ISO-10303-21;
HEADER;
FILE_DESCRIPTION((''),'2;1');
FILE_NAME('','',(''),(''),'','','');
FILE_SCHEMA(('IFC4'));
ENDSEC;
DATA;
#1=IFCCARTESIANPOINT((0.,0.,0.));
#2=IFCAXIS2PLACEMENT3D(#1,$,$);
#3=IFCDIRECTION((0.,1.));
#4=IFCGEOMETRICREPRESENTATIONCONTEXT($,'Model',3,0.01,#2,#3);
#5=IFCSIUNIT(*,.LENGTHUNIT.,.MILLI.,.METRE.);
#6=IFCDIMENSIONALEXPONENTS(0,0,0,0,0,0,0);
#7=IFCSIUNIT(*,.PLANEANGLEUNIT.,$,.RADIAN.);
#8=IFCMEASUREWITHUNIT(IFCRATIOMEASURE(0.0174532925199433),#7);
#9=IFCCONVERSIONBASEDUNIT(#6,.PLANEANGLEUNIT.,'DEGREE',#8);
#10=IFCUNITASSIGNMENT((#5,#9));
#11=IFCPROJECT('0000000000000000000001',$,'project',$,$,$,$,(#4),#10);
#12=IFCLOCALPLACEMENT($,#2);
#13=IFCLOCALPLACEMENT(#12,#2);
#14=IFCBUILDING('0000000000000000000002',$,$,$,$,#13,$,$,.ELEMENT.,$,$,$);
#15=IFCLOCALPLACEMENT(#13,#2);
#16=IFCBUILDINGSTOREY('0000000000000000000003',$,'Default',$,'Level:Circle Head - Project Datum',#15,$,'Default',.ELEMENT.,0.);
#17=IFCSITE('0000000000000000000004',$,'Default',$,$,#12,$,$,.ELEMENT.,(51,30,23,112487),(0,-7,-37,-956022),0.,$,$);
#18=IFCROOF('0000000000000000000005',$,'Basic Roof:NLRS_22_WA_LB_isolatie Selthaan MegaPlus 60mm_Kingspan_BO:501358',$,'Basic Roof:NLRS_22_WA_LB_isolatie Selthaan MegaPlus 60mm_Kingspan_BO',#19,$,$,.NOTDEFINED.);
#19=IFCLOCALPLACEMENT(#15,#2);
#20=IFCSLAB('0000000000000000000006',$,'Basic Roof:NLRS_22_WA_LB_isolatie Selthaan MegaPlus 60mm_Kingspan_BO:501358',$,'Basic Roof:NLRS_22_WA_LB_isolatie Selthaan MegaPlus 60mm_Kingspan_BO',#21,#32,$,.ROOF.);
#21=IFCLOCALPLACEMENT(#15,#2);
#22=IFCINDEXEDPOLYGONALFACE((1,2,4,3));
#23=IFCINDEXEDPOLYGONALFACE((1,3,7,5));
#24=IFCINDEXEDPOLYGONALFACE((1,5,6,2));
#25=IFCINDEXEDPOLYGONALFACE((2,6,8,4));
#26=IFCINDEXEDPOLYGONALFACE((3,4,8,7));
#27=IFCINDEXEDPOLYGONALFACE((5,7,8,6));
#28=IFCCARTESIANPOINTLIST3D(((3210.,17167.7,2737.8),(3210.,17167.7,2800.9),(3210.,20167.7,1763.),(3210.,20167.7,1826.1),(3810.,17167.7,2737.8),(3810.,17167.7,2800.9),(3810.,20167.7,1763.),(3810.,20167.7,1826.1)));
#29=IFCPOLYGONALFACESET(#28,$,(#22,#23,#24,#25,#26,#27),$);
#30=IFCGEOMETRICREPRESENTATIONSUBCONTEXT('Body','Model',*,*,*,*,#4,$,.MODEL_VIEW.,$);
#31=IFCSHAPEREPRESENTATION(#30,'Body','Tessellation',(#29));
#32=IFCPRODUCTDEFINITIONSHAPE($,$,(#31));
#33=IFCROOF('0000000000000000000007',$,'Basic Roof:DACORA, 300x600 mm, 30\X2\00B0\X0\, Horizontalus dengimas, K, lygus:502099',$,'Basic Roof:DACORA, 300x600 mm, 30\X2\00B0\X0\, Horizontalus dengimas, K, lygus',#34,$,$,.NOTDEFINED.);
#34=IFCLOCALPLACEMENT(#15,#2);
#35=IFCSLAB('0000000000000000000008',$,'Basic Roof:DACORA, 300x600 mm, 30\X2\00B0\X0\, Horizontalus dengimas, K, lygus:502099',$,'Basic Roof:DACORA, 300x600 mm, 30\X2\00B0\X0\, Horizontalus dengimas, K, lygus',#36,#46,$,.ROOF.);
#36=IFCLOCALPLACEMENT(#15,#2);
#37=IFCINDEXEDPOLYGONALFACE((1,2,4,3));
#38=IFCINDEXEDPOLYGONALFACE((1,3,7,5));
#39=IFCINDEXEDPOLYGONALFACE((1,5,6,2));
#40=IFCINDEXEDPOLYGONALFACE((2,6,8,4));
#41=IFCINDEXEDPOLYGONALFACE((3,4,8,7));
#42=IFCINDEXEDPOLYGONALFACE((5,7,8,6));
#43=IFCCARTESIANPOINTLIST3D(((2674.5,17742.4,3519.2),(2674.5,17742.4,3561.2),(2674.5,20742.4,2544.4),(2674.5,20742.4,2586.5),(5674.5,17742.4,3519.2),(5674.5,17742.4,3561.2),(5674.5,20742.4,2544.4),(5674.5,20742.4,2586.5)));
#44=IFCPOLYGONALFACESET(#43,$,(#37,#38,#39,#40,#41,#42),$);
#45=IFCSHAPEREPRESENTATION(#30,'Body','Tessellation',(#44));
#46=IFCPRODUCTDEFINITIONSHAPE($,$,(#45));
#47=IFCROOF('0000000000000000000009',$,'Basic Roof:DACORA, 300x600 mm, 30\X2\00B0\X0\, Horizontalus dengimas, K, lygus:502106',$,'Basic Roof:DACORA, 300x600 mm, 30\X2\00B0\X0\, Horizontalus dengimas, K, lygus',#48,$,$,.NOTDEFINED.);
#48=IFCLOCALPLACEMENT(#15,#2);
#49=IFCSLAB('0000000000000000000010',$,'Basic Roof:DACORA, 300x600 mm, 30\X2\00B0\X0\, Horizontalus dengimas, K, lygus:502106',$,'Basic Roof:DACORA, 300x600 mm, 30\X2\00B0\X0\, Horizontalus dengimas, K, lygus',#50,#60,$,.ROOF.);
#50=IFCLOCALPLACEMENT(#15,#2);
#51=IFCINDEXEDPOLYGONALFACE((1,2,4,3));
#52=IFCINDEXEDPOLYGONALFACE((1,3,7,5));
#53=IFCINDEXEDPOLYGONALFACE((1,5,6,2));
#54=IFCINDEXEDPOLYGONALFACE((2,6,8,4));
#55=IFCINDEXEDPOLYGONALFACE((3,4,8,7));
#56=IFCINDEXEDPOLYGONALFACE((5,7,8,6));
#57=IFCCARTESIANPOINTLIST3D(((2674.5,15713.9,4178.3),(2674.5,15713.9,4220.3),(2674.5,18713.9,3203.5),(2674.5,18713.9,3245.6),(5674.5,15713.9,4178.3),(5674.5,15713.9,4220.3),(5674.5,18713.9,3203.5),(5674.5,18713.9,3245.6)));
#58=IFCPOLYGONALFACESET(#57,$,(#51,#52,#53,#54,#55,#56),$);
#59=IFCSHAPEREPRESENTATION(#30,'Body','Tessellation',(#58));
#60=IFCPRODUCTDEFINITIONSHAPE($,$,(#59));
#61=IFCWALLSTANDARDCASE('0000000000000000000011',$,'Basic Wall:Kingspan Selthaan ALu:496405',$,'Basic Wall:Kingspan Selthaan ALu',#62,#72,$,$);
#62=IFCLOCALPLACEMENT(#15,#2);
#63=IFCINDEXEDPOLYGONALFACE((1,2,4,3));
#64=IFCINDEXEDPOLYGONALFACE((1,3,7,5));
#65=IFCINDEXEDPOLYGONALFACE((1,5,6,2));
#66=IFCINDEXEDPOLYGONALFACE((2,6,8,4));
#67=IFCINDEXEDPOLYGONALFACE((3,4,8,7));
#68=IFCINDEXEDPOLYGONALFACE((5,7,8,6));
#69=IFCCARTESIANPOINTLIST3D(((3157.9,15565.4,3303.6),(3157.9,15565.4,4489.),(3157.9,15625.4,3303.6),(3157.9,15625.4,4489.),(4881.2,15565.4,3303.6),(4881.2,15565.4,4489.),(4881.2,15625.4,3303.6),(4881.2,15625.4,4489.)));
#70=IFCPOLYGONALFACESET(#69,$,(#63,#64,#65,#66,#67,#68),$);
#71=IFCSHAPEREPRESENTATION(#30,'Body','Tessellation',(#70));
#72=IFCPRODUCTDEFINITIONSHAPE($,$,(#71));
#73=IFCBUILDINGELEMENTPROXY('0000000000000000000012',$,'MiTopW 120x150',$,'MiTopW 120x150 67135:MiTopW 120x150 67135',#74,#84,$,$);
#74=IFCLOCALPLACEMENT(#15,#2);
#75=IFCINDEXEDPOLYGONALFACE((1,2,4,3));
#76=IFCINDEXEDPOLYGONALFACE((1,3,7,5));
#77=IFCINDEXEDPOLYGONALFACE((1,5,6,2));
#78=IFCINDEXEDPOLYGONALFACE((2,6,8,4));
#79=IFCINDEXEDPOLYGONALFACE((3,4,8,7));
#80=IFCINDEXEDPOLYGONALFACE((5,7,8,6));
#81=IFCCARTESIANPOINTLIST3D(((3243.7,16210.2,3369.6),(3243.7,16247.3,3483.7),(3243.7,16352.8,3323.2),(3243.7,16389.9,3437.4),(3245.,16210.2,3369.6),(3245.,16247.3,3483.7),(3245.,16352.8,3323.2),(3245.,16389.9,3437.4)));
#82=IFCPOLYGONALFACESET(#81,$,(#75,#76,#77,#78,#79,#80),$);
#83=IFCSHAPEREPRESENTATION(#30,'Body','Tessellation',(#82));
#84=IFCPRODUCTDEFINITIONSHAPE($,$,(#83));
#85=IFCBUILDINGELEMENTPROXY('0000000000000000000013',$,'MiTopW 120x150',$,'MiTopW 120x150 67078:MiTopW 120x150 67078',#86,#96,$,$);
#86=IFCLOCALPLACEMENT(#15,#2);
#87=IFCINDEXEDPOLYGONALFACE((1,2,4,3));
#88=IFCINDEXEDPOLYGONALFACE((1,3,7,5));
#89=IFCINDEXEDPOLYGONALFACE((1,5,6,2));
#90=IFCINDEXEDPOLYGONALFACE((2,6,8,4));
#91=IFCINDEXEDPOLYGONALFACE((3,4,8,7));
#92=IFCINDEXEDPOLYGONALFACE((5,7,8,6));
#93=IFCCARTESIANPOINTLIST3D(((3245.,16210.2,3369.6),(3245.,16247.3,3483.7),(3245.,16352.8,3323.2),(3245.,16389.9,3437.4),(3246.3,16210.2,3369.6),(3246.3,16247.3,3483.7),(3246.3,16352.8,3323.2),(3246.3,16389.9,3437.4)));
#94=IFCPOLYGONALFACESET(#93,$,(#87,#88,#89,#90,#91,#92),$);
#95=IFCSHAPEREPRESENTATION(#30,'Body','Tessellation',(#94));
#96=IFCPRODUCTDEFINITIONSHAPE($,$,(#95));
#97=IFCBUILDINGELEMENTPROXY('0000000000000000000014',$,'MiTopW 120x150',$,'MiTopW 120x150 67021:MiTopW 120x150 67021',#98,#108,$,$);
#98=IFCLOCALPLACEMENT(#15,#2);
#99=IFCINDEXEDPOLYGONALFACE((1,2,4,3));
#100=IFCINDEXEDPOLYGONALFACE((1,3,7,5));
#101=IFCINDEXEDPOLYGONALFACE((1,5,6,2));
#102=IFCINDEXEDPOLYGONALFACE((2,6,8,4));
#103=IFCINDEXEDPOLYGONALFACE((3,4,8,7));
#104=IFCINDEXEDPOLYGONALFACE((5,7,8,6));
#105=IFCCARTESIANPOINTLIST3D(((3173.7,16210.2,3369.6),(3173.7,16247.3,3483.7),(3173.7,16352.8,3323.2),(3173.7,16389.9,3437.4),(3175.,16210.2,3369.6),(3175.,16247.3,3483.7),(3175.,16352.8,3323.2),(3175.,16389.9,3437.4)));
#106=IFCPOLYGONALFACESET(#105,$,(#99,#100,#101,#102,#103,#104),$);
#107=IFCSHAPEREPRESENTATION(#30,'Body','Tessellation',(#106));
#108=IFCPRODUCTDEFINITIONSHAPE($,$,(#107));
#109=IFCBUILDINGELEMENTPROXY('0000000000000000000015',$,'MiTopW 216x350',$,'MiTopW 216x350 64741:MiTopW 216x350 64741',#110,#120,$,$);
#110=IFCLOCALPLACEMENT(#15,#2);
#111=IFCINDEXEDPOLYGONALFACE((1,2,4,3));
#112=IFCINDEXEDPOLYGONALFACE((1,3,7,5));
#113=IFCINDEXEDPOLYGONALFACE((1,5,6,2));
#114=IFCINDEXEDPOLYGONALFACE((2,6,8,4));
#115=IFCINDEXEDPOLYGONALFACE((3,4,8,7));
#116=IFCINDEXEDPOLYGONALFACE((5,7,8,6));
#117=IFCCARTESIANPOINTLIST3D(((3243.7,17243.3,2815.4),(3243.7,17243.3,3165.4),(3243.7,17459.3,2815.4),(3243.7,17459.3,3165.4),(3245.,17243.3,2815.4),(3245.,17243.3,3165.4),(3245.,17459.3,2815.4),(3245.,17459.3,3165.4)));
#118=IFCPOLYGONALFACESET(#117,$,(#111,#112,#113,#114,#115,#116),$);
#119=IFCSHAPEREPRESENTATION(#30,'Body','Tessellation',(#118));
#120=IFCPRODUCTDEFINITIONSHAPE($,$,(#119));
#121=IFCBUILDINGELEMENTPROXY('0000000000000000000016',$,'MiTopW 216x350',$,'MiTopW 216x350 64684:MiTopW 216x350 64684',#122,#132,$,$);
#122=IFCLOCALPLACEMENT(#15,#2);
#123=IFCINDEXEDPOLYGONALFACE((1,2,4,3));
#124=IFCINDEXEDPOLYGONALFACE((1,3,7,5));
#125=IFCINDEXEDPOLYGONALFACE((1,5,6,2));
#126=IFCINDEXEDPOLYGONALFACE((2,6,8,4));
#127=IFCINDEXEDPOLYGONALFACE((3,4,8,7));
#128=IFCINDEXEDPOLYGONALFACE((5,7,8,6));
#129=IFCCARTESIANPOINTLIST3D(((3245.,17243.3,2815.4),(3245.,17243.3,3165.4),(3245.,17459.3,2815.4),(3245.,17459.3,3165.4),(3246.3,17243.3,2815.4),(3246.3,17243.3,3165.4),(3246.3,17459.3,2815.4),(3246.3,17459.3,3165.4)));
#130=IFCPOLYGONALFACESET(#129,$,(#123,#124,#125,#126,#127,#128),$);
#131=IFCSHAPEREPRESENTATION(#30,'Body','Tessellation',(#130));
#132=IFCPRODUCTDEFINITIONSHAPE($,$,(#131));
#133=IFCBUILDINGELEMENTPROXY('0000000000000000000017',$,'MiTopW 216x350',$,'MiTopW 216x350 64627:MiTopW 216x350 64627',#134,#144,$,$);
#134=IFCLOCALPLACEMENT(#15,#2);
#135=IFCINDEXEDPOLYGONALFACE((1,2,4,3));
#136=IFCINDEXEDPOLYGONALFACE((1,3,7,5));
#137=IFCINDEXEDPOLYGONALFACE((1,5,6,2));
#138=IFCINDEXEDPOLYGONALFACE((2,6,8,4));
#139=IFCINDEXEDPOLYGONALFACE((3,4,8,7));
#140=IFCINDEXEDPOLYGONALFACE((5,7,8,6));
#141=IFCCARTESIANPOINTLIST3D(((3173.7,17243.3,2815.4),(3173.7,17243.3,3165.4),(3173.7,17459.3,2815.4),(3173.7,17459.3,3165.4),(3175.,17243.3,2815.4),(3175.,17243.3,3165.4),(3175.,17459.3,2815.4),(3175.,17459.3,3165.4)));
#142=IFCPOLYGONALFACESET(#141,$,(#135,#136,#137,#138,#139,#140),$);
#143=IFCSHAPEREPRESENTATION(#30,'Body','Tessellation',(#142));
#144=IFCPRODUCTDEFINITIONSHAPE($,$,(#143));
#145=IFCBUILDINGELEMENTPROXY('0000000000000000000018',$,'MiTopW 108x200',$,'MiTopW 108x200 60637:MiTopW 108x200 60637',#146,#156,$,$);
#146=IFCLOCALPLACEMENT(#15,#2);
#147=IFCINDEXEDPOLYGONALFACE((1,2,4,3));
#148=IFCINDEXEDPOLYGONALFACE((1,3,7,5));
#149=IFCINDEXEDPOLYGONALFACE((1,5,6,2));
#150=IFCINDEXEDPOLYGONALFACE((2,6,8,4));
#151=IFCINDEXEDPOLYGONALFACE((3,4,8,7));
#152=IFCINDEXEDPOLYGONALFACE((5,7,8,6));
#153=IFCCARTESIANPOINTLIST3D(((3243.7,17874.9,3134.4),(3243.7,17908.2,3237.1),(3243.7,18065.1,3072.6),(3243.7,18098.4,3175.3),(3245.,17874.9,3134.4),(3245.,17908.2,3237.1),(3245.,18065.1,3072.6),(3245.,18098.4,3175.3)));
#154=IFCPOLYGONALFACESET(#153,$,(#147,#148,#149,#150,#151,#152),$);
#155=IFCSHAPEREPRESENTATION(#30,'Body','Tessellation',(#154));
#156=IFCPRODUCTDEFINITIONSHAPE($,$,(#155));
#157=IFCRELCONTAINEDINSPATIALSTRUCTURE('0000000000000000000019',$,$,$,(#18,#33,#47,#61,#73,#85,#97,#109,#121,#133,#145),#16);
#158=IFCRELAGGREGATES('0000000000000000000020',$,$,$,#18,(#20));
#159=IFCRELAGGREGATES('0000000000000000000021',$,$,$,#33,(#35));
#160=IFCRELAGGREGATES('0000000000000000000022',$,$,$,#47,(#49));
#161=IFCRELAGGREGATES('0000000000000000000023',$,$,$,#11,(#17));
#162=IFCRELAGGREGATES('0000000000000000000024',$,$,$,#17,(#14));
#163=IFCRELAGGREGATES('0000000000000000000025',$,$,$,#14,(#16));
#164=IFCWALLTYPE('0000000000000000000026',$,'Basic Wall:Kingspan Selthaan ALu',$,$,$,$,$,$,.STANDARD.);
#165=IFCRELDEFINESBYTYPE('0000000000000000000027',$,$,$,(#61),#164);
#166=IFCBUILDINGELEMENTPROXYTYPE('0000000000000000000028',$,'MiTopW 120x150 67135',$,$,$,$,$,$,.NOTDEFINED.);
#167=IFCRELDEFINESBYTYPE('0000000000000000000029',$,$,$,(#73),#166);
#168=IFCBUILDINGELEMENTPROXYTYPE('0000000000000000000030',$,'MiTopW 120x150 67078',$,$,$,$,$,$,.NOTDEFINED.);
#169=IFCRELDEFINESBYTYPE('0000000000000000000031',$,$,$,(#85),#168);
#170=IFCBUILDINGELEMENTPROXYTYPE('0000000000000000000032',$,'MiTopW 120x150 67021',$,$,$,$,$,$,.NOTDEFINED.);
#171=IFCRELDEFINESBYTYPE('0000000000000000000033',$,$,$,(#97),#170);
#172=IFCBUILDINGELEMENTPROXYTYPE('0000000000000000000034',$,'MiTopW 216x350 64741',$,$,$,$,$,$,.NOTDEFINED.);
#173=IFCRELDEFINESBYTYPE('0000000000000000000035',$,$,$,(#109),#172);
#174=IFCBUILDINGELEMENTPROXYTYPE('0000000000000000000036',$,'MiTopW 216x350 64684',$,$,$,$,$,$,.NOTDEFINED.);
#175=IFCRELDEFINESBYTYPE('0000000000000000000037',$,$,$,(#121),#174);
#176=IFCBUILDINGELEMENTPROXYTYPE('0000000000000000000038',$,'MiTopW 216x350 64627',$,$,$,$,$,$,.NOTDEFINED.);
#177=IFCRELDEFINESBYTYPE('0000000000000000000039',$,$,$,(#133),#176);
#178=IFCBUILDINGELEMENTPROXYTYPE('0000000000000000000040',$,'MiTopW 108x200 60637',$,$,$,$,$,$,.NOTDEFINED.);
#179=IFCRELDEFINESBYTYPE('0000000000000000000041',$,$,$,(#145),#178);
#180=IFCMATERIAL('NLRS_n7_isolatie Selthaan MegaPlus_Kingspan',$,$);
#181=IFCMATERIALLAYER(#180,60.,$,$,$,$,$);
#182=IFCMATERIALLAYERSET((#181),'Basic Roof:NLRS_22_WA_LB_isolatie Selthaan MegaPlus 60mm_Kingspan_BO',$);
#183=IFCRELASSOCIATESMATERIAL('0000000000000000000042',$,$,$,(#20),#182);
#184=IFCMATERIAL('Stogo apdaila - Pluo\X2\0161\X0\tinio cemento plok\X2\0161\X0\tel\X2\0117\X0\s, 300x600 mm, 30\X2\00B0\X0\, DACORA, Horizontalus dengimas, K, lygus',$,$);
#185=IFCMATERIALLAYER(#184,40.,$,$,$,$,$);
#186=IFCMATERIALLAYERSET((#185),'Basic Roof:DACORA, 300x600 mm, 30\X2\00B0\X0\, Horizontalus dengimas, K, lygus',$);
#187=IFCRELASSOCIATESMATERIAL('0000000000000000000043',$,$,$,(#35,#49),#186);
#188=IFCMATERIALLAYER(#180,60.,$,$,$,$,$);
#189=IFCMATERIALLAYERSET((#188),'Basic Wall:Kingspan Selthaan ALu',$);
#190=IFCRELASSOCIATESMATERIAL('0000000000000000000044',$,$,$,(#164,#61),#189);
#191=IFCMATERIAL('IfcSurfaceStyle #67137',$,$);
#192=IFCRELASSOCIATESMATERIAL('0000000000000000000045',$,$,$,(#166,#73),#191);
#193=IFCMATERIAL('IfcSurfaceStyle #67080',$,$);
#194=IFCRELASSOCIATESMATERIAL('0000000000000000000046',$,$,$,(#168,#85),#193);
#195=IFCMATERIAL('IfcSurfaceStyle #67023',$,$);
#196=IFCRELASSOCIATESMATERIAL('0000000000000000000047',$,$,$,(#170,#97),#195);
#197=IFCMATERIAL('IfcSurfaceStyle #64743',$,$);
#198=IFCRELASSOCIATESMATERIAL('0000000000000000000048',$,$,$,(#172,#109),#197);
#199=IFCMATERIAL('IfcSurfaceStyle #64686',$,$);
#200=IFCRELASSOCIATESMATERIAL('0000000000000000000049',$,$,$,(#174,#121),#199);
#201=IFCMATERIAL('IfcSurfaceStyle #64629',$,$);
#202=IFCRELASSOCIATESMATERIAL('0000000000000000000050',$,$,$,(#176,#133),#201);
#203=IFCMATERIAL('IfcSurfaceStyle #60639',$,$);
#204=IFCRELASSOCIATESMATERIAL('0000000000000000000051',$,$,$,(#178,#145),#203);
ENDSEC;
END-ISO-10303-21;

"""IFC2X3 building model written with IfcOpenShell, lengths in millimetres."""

from ifc_helpers import new_model, entity, si_unit, converted_unit, direction, frame, frame_2d, origin, origin_2d_with_axis, place, context, subcontext, project, spatial, polyline, rectangle, outline, extrude, source, transform, mapped, material, layer, layer_set, layer_usage, type_object, type_shapes, element, aggregate, save


model = new_model("IFC2X3")

# Units and contexts
model_context = context("Model", 3, precision=0.01, world=origin(), true_north=direction((0.0, 1.0)))
body_context = subcontext(model_context, "Body", "Model", "MODEL_VIEW")
ifc_project = project(units=[si_unit("LENGTHUNIT", "METRE", prefix="MILLI"), converted_unit("PLANEANGLEUNIT", "DEGREE", entity("IfcRatioMeasure", 0.0174532925199433), si_unit("PLANEANGLEUNIT", "RADIAN"), dimensions=[0, 0, 0, 0, 0, 0, 0])], contexts=[model_context])

# Site, building, storey
site_placement = place(None, origin())
site = spatial("IfcSite", under=ifc_project, at=site_placement, Name="Default", CompositionType="ELEMENT", RefLatitude=(51, 30, 23, 112487), RefLongitude=(0, -7, -37, -956022), RefElevation=0.0)
building_placement = place(site_placement, origin())
building = spatial("IfcBuilding", under=site, at=building_placement, CompositionType="ELEMENT")
storey_placement = place(building_placement, origin())
storey = spatial("IfcBuildingStorey", under=building, at=storey_placement, Name="Default", ObjectType="Level:Circle Head - Project Datum", LongName="Default", CompositionType="ELEMENT", Elevation=0.0)

# Roofs, slabs
roof_1_placement = place(storey_placement, frame((3210.0, 17167.7, 1763.0)))
roof_1 = element("IfcRoof", 1, at=roof_1_placement, inside=storey, Name="Basic Roof:NLRS_22_WA_LB_isolatie Selthaan MegaPlus 60mm_Kingspan_BO:501358", ObjectType="Basic Roof:NLRS_22_WA_LB_isolatie Selthaan MegaPlus 60mm_Kingspan_BO", ShapeType="NOTDEFINED")
ifc_material_1 = material(Name="NLRS_n7_isolatie Selthaan MegaPlus_Kingspan")
ifc_layer_1 = layer(ifc_material_1, 60.0)
ifc_layer_set_1 = layer_set([ifc_layer_1], Name="Basic Roof:NLRS_22_WA_LB_isolatie Selthaan MegaPlus 60mm_Kingspan_BO")
slab_1_placement = place(roof_1_placement, origin())
slab_1 = element("IfcSlab", 2, at=slab_1_placement, material=ifc_layer_set_1, Name="Basic Roof:NLRS_22_WA_LB_isolatie Selthaan MegaPlus 60mm_Kingspan_BO:501358", ObjectType="Basic Roof:NLRS_22_WA_LB_isolatie Selthaan MegaPlus 60mm_Kingspan_BO", PredefinedType="ROOF", context=body_context, shape_type="SweptSolid", body=[
    extrude(rectangle(XDim=600.0, YDim=3154.4, at=frame_2d((0.0, 0.0), x_axis=(-1.0, 0.0))), frame((300.0, 1500.0, 487.4), z_axis=(0.0, 0.309017, 0.951057), x_axis=(1.0, 0.0, 0.0)), (0.0, -0.309017, 0.951057), 63.1),
])
aggregate(roof_1, [slab_1])
roof_2_placement = place(storey_placement, frame((2674.5, 17742.4, 2544.4)))
roof_2 = element("IfcRoof", 3, at=roof_2_placement, inside=storey, Name="Basic Roof:DACORA, 300x600 mm, 30°, Horizontalus dengimas, K, lygus:502099", ObjectType="Basic Roof:DACORA, 300x600 mm, 30°, Horizontalus dengimas, K, lygus", ShapeType="NOTDEFINED")
ifc_material_2 = material(Name="Stogo apdaila - Pluoštinio cemento plokštelės, 300x600 mm, 30°, DACORA, Horizontalus dengimas, K, lygus")
ifc_layer_2 = layer(ifc_material_2, 40.0)
ifc_layer_set_2 = layer_set([ifc_layer_2], Name="Basic Roof:DACORA, 300x600 mm, 30°, Horizontalus dengimas, K, lygus")
slab_2_placement = place(roof_2_placement, origin())
slab_2 = element("IfcSlab", 4, at=slab_2_placement, material=ifc_layer_set_2, Name="Basic Roof:DACORA, 300x600 mm, 30°, Horizontalus dengimas, K, lygus:502099", ObjectType="Basic Roof:DACORA, 300x600 mm, 30°, Horizontalus dengimas, K, lygus", PredefinedType="ROOF", context=body_context, shape_type="SweptSolid", body=[
    extrude(rectangle(XDim=3154.4, YDim=3000.0, at=frame_2d((0.0, 0.0), x_axis=(0.0, 1.0))), frame((1500.0, 1500.0, 487.4), z_axis=(0.0, 0.309017, 0.951057), x_axis=(1.0, 0.0, 0.0)), (0.0, -0.309017, 0.951057), 42.1),
])
aggregate(roof_2, [slab_2])
roof_3_placement = place(storey_placement, frame((2674.5, 15713.9, 3203.5)))
roof_3 = element("IfcRoof", 5, at=roof_3_placement, inside=storey, Name="Basic Roof:DACORA, 300x600 mm, 30°, Horizontalus dengimas, K, lygus:502106", ObjectType="Basic Roof:DACORA, 300x600 mm, 30°, Horizontalus dengimas, K, lygus", ShapeType="NOTDEFINED")
slab_3_placement = place(roof_3_placement, origin())
slab_3 = element("IfcSlab", 6, at=slab_3_placement, material=ifc_layer_set_2, Name="Basic Roof:DACORA, 300x600 mm, 30°, Horizontalus dengimas, K, lygus:502106", ObjectType="Basic Roof:DACORA, 300x600 mm, 30°, Horizontalus dengimas, K, lygus", PredefinedType="ROOF", context=body_context, shape_type="SweptSolid", body=[
    extrude(rectangle(XDim=3154.4, YDim=3000.0, at=frame_2d((0.0, 0.0), x_axis=(0.0, 1.0))), frame((1500.0, 1500.0, 487.4), z_axis=(0.0, 0.309017, 0.951057), x_axis=(1.0, 0.0, 0.0)), (0.0, -0.309017, 0.951057), 42.1),
])
aggregate(roof_3, [slab_3])

# Wall
ifc_layer_3 = layer(ifc_material_1, 60.0)
ifc_layer_set_3 = layer_set([ifc_layer_3], Name="Basic Wall:Kingspan Selthaan ALu")
ifc_layer_usage = layer_usage(ifc_layer_set_3, "AXIS2", "NEGATIVE", 30.0)
wall_type = type_object("IfcWallType", Name="Basic Wall:Kingspan Selthaan ALu", PredefinedType="STANDARD", material=ifc_layer_set_3)
wall_placement = place(storey_placement, frame((3157.9, 15595.4, 3303.6)))
element("IfcWallStandardCase", 7, at=wall_placement, inside=storey, type_object=wall_type, material=ifc_layer_usage, Name="Basic Wall:Kingspan Selthaan ALu:496405", ObjectType="Basic Wall:Kingspan Selthaan ALu", context=body_context, shape_type="SweptSolid", body=[
    extrude(rectangle(XDim=1723.2, YDim=60.0, at=frame_2d((861.6, 0.0), x_axis=(-1.0, 0.0))), origin(), (0.0, 0.0, 1.0), 1185.4),
])

# Building element proxies
ifc_material_3 = material(Name="IfcSurfaceStyle #67137")
building_element_proxy_type_1 = type_object("IfcBuildingElementProxyType", Name="MiTopW 120x150 67135", PredefinedType="NOTDEFINED", material=ifc_material_3)
shared_shape_1 = source(origin(), body_context, "Body", "SweptSolid", [
    extrude(outline(polyline([(-75.0, -60.0), (75.0, -60.0), (75.0, 60.0), (-75.0, 60.0), (-75.0, -60.0)])), frame((75.0, 60.0, 0.0), z_axis=(0.0, 0.0, 1.0), x_axis=(-1.0, 0.0, 0.0)), (0.0, 0.0, 1.0), 1.3),
])
type_shapes(building_element_proxy_type_1, [shared_shape_1])
proxy_1_placement = place(building_placement, frame((3245.0, 16352.8, 3323.2), z_axis=(-1.0, 0.0, 0.0), x_axis=(0.0, -0.951057, 0.309017)))
element("IfcBuildingElementProxy", 8, at=proxy_1_placement, inside=storey, type_object=building_element_proxy_type_1, material=ifc_material_3, Name="MiTopW 120x150", ObjectType="MiTopW 120x150 67135:MiTopW 120x150 67135", context=body_context, shape_type="MappedRepresentation", body=[
    mapped(shared_shape_1, transform((0.0, 0.0, 0.0), scale=1.0)),
])
ifc_material_4 = material(Name="IfcSurfaceStyle #67080")
building_element_proxy_type_2 = type_object("IfcBuildingElementProxyType", Name="MiTopW 120x150 67078", PredefinedType="NOTDEFINED", material=ifc_material_4)
shared_shape_2 = source(origin(), body_context, "Body", "SweptSolid", [
    extrude(outline(polyline([(-75.0, -60.0), (75.0, -60.0), (75.0, 60.0), (-75.0, 60.0), (-75.0, -60.0)])), frame((75.0, 60.0, 0.0), z_axis=(0.0, 0.0, 1.0), x_axis=(-1.0, 0.0, 0.0)), (0.0, 0.0, 1.0), 1.3),
])
type_shapes(building_element_proxy_type_2, [shared_shape_2])
proxy_2_placement = place(building_placement, frame((3246.3, 16352.8, 3323.2), z_axis=(-1.0, 0.0, 0.0), x_axis=(0.0, -0.951057, 0.309017)))
element("IfcBuildingElementProxy", 9, at=proxy_2_placement, inside=storey, type_object=building_element_proxy_type_2, material=ifc_material_4, Name="MiTopW 120x150", ObjectType="MiTopW 120x150 67078:MiTopW 120x150 67078", context=body_context, shape_type="MappedRepresentation", body=[
    mapped(shared_shape_2, transform((0.0, 0.0, 0.0), scale=1.0)),
])
ifc_material_5 = material(Name="IfcSurfaceStyle #67023")
building_element_proxy_type_3 = type_object("IfcBuildingElementProxyType", Name="MiTopW 120x150 67021", PredefinedType="NOTDEFINED", material=ifc_material_5)
shared_shape_3 = source(origin(), body_context, "Body", "SweptSolid", [
    extrude(outline(polyline([(-75.0, -60.0), (75.0, -60.0), (75.0, 60.0), (-75.0, 60.0), (-75.0, -60.0)])), frame((75.0, 60.0, 0.0), z_axis=(0.0, 0.0, 1.0), x_axis=(-1.0, 0.0, 0.0)), (0.0, 0.0, 1.0), 1.3),
])
type_shapes(building_element_proxy_type_3, [shared_shape_3])
proxy_3_placement = place(building_placement, frame((3175.0, 16352.8, 3323.2), z_axis=(-1.0, 0.0, 0.0), x_axis=(0.0, -0.951057, 0.309017)))
element("IfcBuildingElementProxy", 10, at=proxy_3_placement, inside=storey, type_object=building_element_proxy_type_3, material=ifc_material_5, Name="MiTopW 120x150", ObjectType="MiTopW 120x150 67021:MiTopW 120x150 67021", context=body_context, shape_type="MappedRepresentation", body=[
    mapped(shared_shape_3, transform((0.0, 0.0, 0.0), scale=1.0)),
])
ifc_material_6 = material(Name="IfcSurfaceStyle #64743")
building_element_proxy_type_4 = type_object("IfcBuildingElementProxyType", Name="MiTopW 216x350 64741", PredefinedType="NOTDEFINED", material=ifc_material_6)
shared_shape_4 = source(origin(), body_context, "Body", "SweptSolid", [
    extrude(rectangle(XDim=350.0, YDim=216.0, at=origin_2d_with_axis()), frame((175.0, 108.0, 0.0), z_axis=(0.0, 0.0, 1.0), x_axis=(-1.0, 0.0, 0.0)), (0.0, 0.0, 1.0), 1.3),
])
type_shapes(building_element_proxy_type_4, [shared_shape_4])
proxy_4_placement = place(building_placement, frame((3245.0, 17459.3, 3165.4), z_axis=(-1.0, 0.0, 0.0), x_axis=(0.0, 0.0, -1.0)))
element("IfcBuildingElementProxy", 11, at=proxy_4_placement, inside=storey, type_object=building_element_proxy_type_4, material=ifc_material_6, Name="MiTopW 216x350", ObjectType="MiTopW 216x350 64741:MiTopW 216x350 64741", context=body_context, shape_type="MappedRepresentation", body=[
    mapped(shared_shape_4, transform((0.0, 0.0, 0.0), scale=1.0)),
])
ifc_material_7 = material(Name="IfcSurfaceStyle #64686")
building_element_proxy_type_5 = type_object("IfcBuildingElementProxyType", Name="MiTopW 216x350 64684", PredefinedType="NOTDEFINED", material=ifc_material_7)
shared_shape_5 = source(origin(), body_context, "Body", "SweptSolid", [
    extrude(rectangle(XDim=350.0, YDim=216.0, at=origin_2d_with_axis()), frame((175.0, 108.0, 0.0), z_axis=(0.0, 0.0, 1.0), x_axis=(-1.0, 0.0, 0.0)), (0.0, 0.0, 1.0), 1.3),
])
type_shapes(building_element_proxy_type_5, [shared_shape_5])
proxy_5_placement = place(building_placement, frame((3246.3, 17459.3, 3165.4), z_axis=(-1.0, 0.0, 0.0), x_axis=(0.0, 0.0, -1.0)))
element("IfcBuildingElementProxy", 12, at=proxy_5_placement, inside=storey, type_object=building_element_proxy_type_5, material=ifc_material_7, Name="MiTopW 216x350", ObjectType="MiTopW 216x350 64684:MiTopW 216x350 64684", context=body_context, shape_type="MappedRepresentation", body=[
    mapped(shared_shape_5, transform((0.0, 0.0, 0.0), scale=1.0)),
])
ifc_material_8 = material(Name="IfcSurfaceStyle #64629")
building_element_proxy_type_6 = type_object("IfcBuildingElementProxyType", Name="MiTopW 216x350 64627", PredefinedType="NOTDEFINED", material=ifc_material_8)
shared_shape_6 = source(origin(), body_context, "Body", "SweptSolid", [
    extrude(rectangle(XDim=350.0, YDim=216.0, at=origin_2d_with_axis()), frame((175.0, 108.0, 0.0), z_axis=(0.0, 0.0, 1.0), x_axis=(-1.0, 0.0, 0.0)), (0.0, 0.0, 1.0), 1.3),
])
type_shapes(building_element_proxy_type_6, [shared_shape_6])
proxy_6_placement = place(building_placement, frame((3175.0, 17459.3, 3165.4), z_axis=(-1.0, 0.0, 0.0), x_axis=(0.0, 0.0, -1.0)))
element("IfcBuildingElementProxy", 13, at=proxy_6_placement, inside=storey, type_object=building_element_proxy_type_6, material=ifc_material_8, Name="MiTopW 216x350", ObjectType="MiTopW 216x350 64627:MiTopW 216x350 64627", context=body_context, shape_type="MappedRepresentation", body=[
    mapped(shared_shape_6, transform((0.0, 0.0, 0.0), scale=1.0)),
])
ifc_material_9 = material(Name="IfcSurfaceStyle #60639")
building_element_proxy_type_7 = type_object("IfcBuildingElementProxyType", Name="MiTopW 108x200 60637", PredefinedType="NOTDEFINED", material=ifc_material_9)
shared_shape_7 = source(origin(), body_context, "Body", "SweptSolid", [
    extrude(outline(polyline([(-100.0, -54.0), (100.0, -54.0), (100.0, 54.0), (-100.0, 54.0), (-100.0, -54.0)])), frame((100.0, 54.0, 0.0), z_axis=(0.0, 0.0, 1.0), x_axis=(-1.0, 0.0, 0.0)), (0.0, 0.0, 1.0), 1.3),
])
type_shapes(building_element_proxy_type_7, [shared_shape_7])
proxy_7_placement = place(building_placement, frame((3245.0, 18065.1, 3072.6), z_axis=(-1.0, 0.0, 0.0), x_axis=(0.0, -0.951057, 0.309017)))
element("IfcBuildingElementProxy", 14, at=proxy_7_placement, inside=storey, type_object=building_element_proxy_type_7, material=ifc_material_9, Name="MiTopW 108x200", ObjectType="MiTopW 108x200 60637:MiTopW 108x200 60637", context=body_context, shape_type="MappedRepresentation", body=[
    mapped(shared_shape_7, transform((0.0, 0.0, 0.0), scale=1.0)),
])

save(model, "model.ifc")
